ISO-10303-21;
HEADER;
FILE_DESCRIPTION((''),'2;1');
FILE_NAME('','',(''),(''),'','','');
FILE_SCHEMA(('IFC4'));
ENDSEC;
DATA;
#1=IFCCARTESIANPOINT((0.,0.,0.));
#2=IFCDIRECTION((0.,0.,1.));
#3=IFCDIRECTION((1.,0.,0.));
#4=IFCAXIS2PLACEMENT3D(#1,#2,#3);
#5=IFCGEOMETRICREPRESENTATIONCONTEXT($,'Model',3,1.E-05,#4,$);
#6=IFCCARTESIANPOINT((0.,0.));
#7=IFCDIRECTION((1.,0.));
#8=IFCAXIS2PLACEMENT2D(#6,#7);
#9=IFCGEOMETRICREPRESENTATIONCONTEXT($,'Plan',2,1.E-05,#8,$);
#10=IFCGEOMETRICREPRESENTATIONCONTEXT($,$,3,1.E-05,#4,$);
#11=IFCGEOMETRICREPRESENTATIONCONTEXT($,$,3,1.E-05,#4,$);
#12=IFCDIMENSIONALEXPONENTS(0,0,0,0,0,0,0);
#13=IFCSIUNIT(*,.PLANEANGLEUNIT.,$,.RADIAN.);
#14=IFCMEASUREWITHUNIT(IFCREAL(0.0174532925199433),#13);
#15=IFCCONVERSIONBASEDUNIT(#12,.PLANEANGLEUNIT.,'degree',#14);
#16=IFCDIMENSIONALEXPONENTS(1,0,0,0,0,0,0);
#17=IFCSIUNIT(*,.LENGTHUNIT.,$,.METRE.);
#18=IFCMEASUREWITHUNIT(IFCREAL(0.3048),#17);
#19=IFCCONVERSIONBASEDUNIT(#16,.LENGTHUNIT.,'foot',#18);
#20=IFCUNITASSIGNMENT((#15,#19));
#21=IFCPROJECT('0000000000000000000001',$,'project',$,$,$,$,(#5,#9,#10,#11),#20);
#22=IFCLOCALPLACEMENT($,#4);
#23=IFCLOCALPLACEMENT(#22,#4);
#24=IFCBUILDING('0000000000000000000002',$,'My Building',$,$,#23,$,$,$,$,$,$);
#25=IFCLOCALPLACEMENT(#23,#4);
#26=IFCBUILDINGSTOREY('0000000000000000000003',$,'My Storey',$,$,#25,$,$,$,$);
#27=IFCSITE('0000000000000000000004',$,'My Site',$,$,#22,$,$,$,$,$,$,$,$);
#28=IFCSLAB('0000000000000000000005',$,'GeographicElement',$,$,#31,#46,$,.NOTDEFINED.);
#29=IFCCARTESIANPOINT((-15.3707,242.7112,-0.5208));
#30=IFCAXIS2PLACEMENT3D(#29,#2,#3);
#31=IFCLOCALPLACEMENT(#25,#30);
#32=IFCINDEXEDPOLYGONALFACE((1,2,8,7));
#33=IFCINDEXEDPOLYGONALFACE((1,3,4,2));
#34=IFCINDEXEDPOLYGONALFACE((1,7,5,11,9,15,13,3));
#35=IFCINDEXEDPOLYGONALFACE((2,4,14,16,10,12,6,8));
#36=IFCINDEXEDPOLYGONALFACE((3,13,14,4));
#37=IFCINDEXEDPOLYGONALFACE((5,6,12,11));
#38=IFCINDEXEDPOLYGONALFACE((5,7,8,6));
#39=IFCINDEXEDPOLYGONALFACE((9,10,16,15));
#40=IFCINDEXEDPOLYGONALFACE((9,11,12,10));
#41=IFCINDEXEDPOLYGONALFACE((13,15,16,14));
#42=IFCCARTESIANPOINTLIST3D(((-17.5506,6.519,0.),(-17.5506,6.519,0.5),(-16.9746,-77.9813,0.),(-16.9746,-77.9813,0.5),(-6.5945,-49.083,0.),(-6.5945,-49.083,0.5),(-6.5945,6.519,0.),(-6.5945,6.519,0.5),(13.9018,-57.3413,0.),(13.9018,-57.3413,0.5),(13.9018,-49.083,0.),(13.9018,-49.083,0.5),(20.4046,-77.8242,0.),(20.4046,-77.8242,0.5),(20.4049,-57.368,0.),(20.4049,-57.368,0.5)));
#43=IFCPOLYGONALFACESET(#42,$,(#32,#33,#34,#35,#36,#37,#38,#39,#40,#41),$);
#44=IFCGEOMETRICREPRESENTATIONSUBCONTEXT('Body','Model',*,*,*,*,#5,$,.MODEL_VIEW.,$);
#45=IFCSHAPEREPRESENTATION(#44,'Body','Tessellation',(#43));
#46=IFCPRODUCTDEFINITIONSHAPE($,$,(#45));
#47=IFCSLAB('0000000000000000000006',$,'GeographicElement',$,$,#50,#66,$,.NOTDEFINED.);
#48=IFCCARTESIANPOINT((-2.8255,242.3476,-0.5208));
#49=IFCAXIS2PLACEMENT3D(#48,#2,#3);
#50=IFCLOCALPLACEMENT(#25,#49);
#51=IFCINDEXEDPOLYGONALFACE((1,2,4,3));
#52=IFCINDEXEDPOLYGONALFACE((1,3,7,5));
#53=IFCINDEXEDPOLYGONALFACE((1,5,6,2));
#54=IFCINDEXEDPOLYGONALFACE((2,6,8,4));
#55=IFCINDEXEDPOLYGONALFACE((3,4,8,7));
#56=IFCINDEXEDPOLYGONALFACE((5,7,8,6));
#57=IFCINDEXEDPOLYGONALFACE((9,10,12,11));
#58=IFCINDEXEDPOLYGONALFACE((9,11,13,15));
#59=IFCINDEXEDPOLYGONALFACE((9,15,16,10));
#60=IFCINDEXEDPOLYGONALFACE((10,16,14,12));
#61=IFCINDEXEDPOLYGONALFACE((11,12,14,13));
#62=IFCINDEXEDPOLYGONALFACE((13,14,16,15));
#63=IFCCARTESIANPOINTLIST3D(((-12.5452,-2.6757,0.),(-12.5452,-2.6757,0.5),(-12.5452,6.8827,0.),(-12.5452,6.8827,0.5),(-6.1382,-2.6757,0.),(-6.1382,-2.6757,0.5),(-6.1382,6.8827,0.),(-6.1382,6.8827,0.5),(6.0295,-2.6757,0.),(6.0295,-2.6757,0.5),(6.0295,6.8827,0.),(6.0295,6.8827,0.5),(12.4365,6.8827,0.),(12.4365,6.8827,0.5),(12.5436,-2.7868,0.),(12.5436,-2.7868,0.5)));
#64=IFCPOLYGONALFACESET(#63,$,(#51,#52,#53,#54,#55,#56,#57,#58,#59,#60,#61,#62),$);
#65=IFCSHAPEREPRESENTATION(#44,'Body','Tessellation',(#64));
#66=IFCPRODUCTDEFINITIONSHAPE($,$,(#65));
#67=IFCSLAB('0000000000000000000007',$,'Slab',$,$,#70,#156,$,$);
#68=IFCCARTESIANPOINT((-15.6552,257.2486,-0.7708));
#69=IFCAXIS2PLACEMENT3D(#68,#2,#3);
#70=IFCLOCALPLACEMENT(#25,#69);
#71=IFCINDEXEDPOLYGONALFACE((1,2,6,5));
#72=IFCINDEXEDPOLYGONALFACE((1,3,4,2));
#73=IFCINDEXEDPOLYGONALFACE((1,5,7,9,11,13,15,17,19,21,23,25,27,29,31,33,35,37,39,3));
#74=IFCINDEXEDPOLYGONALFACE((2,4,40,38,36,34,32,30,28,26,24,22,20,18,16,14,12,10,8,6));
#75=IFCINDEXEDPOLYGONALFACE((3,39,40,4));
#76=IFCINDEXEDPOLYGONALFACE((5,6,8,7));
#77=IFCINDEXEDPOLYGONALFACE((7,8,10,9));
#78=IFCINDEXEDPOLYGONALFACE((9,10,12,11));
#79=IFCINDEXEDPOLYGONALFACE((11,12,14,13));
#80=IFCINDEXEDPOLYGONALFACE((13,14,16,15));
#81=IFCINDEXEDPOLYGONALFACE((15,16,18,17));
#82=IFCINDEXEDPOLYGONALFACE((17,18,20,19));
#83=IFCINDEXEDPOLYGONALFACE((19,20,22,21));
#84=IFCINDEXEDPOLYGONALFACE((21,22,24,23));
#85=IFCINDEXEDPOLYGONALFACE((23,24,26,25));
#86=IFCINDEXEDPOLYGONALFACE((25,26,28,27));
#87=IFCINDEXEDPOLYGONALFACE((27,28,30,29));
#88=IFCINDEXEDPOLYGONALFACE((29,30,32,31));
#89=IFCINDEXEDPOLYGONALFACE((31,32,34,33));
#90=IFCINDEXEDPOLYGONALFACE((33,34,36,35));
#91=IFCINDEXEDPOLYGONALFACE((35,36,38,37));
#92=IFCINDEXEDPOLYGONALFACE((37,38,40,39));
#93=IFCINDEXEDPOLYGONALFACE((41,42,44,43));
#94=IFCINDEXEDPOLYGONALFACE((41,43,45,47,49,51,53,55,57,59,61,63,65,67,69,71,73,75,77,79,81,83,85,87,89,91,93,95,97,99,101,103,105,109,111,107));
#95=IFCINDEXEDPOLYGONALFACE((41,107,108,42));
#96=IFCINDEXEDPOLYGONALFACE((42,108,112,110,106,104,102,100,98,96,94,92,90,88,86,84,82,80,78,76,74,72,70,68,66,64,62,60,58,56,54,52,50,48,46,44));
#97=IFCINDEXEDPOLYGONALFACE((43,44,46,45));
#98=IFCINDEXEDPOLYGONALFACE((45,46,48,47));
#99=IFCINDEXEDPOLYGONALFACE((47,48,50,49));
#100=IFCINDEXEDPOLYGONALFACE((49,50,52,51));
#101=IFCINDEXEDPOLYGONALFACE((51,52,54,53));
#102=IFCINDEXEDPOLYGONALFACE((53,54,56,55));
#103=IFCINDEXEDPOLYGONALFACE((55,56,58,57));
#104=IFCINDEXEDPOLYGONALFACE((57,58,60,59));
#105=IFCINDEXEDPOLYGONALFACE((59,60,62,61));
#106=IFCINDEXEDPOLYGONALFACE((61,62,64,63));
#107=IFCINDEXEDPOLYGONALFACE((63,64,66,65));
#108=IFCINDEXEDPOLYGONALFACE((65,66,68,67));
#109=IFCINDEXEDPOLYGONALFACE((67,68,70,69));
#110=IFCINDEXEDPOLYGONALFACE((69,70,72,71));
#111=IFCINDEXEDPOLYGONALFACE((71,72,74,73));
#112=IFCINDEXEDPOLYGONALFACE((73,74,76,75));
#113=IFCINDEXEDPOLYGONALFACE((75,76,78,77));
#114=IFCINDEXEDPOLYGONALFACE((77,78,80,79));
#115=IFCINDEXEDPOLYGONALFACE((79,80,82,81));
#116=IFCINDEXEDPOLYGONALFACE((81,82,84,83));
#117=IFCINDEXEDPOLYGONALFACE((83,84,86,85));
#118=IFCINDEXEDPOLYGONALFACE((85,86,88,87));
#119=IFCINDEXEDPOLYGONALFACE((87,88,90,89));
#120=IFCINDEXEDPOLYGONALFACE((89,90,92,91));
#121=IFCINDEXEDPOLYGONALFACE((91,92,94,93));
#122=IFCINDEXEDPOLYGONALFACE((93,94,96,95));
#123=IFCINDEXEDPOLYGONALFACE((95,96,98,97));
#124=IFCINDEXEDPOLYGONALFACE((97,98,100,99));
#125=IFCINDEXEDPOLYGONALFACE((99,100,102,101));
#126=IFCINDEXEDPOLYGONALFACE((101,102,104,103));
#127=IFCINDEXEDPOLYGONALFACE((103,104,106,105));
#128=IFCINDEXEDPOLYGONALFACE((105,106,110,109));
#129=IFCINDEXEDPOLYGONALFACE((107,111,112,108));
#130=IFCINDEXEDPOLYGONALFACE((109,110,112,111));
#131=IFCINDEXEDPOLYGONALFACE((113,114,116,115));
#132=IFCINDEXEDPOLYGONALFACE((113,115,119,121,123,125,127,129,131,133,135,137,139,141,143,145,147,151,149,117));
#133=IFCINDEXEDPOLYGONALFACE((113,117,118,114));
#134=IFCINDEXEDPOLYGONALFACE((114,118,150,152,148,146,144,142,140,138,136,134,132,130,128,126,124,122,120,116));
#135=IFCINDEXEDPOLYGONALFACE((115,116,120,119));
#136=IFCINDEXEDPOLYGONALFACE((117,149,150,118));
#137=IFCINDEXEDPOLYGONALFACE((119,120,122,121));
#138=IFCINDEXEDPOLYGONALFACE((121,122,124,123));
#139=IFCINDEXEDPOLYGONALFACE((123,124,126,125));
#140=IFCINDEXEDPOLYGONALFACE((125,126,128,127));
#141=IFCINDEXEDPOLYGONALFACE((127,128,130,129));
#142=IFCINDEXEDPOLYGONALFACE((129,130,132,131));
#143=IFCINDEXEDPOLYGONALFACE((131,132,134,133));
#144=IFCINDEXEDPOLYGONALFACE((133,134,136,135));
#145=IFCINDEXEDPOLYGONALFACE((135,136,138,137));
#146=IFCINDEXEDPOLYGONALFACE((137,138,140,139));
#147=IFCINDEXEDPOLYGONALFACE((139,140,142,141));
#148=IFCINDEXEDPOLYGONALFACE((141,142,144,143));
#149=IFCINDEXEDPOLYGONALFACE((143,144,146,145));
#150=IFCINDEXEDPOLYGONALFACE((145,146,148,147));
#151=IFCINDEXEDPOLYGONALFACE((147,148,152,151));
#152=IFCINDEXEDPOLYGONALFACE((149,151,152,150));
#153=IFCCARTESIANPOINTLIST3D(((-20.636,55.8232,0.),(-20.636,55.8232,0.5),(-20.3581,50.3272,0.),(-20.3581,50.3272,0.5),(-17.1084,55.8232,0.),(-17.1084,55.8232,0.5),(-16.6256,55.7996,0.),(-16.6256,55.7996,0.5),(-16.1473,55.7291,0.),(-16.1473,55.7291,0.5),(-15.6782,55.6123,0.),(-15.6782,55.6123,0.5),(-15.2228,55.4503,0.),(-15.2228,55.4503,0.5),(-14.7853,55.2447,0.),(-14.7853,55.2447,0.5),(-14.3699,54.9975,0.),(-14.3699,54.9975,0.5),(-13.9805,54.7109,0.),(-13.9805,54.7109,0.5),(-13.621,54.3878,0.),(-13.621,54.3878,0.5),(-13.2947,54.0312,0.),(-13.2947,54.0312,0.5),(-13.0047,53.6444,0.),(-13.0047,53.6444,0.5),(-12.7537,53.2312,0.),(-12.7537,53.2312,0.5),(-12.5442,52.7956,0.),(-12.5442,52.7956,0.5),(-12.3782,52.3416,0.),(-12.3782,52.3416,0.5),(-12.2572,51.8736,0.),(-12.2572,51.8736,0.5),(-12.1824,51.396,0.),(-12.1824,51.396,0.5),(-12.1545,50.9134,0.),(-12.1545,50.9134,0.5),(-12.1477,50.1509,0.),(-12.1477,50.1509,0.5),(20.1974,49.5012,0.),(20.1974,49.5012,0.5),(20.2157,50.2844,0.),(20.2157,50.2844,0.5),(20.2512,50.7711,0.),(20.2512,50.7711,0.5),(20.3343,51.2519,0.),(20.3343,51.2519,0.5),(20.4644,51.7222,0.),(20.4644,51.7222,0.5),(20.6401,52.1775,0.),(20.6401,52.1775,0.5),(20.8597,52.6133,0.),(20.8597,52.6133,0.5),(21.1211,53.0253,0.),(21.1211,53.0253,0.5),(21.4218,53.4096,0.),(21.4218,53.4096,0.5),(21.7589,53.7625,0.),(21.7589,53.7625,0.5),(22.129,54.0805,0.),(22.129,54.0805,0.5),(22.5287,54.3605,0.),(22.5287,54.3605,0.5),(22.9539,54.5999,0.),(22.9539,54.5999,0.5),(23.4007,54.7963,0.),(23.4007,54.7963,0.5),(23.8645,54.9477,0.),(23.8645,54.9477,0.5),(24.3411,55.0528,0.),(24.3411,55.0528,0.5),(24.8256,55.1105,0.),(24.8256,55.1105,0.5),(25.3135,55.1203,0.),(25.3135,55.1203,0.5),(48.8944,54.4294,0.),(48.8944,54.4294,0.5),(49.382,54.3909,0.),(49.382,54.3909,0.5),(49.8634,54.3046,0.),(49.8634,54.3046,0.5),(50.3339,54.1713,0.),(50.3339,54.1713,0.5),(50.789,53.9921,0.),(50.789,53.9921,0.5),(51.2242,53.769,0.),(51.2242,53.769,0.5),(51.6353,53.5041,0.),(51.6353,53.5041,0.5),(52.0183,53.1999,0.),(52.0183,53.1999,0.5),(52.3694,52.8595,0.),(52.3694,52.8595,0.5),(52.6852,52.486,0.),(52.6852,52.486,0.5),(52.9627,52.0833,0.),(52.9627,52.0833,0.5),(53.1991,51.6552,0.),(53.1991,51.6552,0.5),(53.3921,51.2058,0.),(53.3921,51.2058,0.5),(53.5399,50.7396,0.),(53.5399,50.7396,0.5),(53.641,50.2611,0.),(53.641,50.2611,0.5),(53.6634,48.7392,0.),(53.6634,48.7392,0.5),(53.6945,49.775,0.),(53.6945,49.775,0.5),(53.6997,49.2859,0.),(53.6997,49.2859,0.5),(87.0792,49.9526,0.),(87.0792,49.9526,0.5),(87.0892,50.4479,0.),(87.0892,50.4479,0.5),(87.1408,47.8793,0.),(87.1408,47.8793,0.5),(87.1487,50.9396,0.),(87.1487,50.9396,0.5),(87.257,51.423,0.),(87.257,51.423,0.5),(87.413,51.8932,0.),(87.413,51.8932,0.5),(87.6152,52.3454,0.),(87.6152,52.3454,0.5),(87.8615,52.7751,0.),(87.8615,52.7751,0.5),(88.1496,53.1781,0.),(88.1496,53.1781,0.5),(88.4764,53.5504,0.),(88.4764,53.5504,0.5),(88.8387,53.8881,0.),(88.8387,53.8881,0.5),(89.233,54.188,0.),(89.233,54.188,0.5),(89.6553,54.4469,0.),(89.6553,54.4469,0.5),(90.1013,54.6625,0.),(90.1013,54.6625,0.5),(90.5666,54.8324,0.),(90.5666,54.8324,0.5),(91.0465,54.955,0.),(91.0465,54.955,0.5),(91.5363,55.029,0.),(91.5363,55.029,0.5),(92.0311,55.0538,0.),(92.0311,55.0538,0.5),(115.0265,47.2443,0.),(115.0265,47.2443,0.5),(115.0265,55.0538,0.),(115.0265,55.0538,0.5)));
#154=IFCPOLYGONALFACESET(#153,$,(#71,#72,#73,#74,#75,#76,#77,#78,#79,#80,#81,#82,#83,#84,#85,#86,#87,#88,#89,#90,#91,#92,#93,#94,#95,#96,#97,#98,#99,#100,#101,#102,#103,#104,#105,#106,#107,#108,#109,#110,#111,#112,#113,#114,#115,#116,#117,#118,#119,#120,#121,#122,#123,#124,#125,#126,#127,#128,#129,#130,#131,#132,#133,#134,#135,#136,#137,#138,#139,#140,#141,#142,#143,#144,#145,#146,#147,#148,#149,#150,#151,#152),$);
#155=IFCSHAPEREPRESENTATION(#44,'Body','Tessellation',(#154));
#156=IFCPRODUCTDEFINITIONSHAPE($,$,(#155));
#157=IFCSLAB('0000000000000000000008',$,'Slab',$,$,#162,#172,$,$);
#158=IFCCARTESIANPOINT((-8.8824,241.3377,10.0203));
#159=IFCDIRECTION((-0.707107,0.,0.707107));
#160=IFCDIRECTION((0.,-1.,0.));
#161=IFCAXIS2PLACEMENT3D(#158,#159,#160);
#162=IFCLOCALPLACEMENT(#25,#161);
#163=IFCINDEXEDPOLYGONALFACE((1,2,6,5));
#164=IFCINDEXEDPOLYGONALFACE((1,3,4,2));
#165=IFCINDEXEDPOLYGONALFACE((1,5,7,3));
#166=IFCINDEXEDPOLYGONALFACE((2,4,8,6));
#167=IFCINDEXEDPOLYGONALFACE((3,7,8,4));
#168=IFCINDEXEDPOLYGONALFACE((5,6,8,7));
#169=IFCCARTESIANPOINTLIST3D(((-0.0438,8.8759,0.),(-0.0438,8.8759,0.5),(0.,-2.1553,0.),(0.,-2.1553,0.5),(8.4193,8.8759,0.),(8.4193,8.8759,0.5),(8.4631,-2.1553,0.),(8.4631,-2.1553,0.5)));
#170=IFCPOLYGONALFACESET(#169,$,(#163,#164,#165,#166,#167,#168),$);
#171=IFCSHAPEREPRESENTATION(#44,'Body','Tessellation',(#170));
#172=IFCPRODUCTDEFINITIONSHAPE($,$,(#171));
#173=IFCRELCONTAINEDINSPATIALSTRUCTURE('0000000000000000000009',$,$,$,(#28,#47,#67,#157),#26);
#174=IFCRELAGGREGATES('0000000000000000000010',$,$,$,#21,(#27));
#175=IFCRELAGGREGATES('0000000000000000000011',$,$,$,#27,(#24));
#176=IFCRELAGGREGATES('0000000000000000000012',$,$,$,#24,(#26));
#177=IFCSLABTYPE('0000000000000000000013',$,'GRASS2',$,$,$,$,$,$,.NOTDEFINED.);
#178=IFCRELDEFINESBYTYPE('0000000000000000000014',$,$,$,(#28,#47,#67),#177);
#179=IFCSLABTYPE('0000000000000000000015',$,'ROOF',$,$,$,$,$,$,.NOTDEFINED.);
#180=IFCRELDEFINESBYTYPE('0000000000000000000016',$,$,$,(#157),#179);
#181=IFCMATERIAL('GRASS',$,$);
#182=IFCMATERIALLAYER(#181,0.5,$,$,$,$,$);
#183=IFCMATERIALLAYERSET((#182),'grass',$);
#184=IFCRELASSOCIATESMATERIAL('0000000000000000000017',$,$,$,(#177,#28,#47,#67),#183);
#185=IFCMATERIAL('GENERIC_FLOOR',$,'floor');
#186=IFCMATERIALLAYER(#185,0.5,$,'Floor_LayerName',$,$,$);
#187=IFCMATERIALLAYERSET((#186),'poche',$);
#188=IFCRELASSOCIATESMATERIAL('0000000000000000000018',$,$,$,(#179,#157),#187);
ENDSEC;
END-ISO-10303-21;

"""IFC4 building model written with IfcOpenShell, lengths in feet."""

from ifc_helpers import new_model, entity, si_unit, converted_unit, frame, origin_with_axes, origin_2d_with_axis, place, context, subcontext, project, spatial, line, arc, indexed_curve, outline, extrude, material, layer, layer_set, layer_usage, type_object, element, save


model = new_model("IFC4")

# Units and contexts
model_context = context("Model", 3, precision=1e-05, world=origin_with_axes())
plan_context = context("Plan", 2, precision=1e-05, world=origin_2d_with_axis())
context_of_model_1 = context(None, 3, precision=1e-05, world=origin_with_axes())
context_of_model_2 = context(None, 3, precision=1e-05, world=origin_with_axes())
body_context_1 = subcontext(model_context, "Body", "Model", "MODEL_VIEW")
ifc_project = project(units=[converted_unit("PLANEANGLEUNIT", "degree", entity("IfcReal", 0.0174532925199433), si_unit("PLANEANGLEUNIT", "RADIAN"), dimensions=[0, 0, 0, 0, 0, 0, 0]), converted_unit("LENGTHUNIT", "foot", entity("IfcReal", 0.3048), si_unit("LENGTHUNIT", "METRE"), dimensions=[1, 0, 0, 0, 0, 0, 0])], contexts=[model_context, plan_context, context_of_model_1, context_of_model_2])

# Site, building, storey
site_placement = place(None, origin_with_axes())
site = spatial("IfcSite", under=ifc_project, at=site_placement, Name="My Site")
building_placement = place(site_placement, origin_with_axes())
building = spatial("IfcBuilding", under=site, at=building_placement, Name="My Building")
storey_placement = place(building_placement, origin_with_axes())
storey = spatial("IfcBuildingStorey", under=building, at=storey_placement, Name="My Storey")

# Slabs
ifc_material_1 = material(Name="GRASS")
ifc_layer_1 = layer(ifc_material_1, 0.5)
ifc_layer_set_1 = layer_set([ifc_layer_1], Name="grass")
ifc_layer_usage_1 = layer_usage(ifc_layer_set_1, "AXIS3", "POSITIVE", 0.0)
slab_type_1 = type_object("IfcSlabType", Name="GRASS2", PredefinedType="NOTDEFINED", material=ifc_layer_set_1)
slab_1_placement = place(storey_placement, frame((-15.3707, 242.7112, -0.5208), z_axis=(0.0, 0.0, 1.0), x_axis=(1.0, 0.0, 0.0)))
element("IfcSlab", 1, at=slab_1_placement, inside=storey, type_object=slab_type_1, material=ifc_layer_usage_1, Name="GeographicElement", PredefinedType="NOTDEFINED", context=body_context_1, shape_type="SweptSolid", body=[
    extrude(outline(indexed_curve([(-6.5945, 6.519), (-6.5945, -49.083), (13.9018, -49.083), (13.9018, -57.3413), (20.4049, -57.368), (20.4046, -77.8242), (-16.9746, -77.9813), (-17.5506, 6.519)], segments=[line(3, 2), line(2, 1), line(1, 8), line(8, 7), line(7, 6), line(6, 5), line(5, 4), line(4, 3)], self_intersect=False)), None, (0.0, 0.0, 1.0), 0.5),
])
ifc_layer_usage_2 = layer_usage(ifc_layer_set_1, "AXIS3", "POSITIVE", 0.0)
slab_2_placement = place(storey_placement, frame((-2.8255, 242.3476, -0.5208), z_axis=(0.0, 0.0, 1.0), x_axis=(1.0, 0.0, 0.0)))
element("IfcSlab", 2, at=slab_2_placement, inside=storey, type_object=slab_type_1, material=ifc_layer_usage_2, Name="GeographicElement", PredefinedType="NOTDEFINED", context=body_context_1, shape_type="SweptSolid", body=[
    extrude(outline(indexed_curve([(-12.5452, -2.6757), (-6.1382, -2.6757), (-6.1382, 6.8827), (-12.5452, 6.8827), (6.0295, -2.6757), (6.0295, 6.8827), (12.4365, 6.8827), (12.5436, -2.7868)], segments=[line(7, 6), line(6, 5), line(5, 8), line(8, 7)], self_intersect=False), holes=[indexed_curve([(-12.5452, -2.6757), (-6.1382, -2.6757), (-6.1382, 6.8827), (-12.5452, 6.8827), (6.0295, -2.6757), (6.0295, 6.8827), (12.4365, 6.8827), (12.5436, -2.7868)], segments=[line(3, 4), line(4, 1), line(1, 2), line(2, 3)], self_intersect=False)]), None, (0.0, 0.0, 1.0), 0.5),
])
ifc_layer_usage_3 = layer_usage(ifc_layer_set_1, "AXIS3", "POSITIVE", 0.0)
slab_3_placement = place(storey_placement, frame((-15.6552, 257.2486, -0.7708), z_axis=(0.0, 0.0, 1.0), x_axis=(1.0, 0.0, 0.0)))
element("IfcSlab", 3, at=slab_3_placement, inside=storey, type_object=slab_type_1, material=ifc_layer_usage_3, Name="Slab", context=body_context_1, shape_type="SweptSolid", body=[
    extrude(outline(indexed_curve([(87.1408, 47.8793), (115.0265, 47.2443), (115.0265, 55.0538), (92.0311, 55.0538), (88.4764, 53.5504), (87.0792, 49.9526), (25.3135, 55.1203), (21.7589, 53.7625), (20.2157, 50.2844), (20.1974, 49.5012), (53.6634, 48.7392), (53.6997, 49.2859), (52.3694, 52.8595), (48.8944, 54.4294), (-12.1477, 50.1509), (-20.3581, 50.3272), (-20.636, 55.8232), (-17.1084, 55.8232), (-13.621, 54.3878), (-12.1545, 50.9134)], segments=[line(1, 2), line(2, 3), line(3, 4), arc(4, 5, 6), line(6, 1)], self_intersect=False), holes=[indexed_curve([(87.1408, 47.8793), (115.0265, 47.2443), (115.0265, 55.0538), (92.0311, 55.0538), (88.4764, 53.5504), (87.0792, 49.9526), (25.3135, 55.1203), (21.7589, 53.7625), (20.2157, 50.2844), (20.1974, 49.5012), (53.6634, 48.7392), (53.6997, 49.2859), (52.3694, 52.8595), (48.8944, 54.4294), (-12.1477, 50.1509), (-20.3581, 50.3272), (-20.636, 55.8232), (-17.1084, 55.8232), (-13.621, 54.3878), (-12.1545, 50.9134)], segments=[line(17, 16), line(16, 15), line(15, 20), arc(20, 19, 18), line(18, 17)], self_intersect=False), indexed_curve([(87.1408, 47.8793), (115.0265, 47.2443), (115.0265, 55.0538), (92.0311, 55.0538), (88.4764, 53.5504), (87.0792, 49.9526), (25.3135, 55.1203), (21.7589, 53.7625), (20.2157, 50.2844), (20.1974, 49.5012), (53.6634, 48.7392), (53.6997, 49.2859), (52.3694, 52.8595), (48.8944, 54.4294), (-12.1477, 50.1509), (-20.3581, 50.3272), (-20.636, 55.8232), (-17.1084, 55.8232), (-13.621, 54.3878), (-12.1545, 50.9134)], segments=[line(11, 12), arc(12, 13, 14), line(14, 7), arc(7, 8, 9), line(9, 10), line(10, 11)], self_intersect=False)]), None, (0.0, 0.0, 1.0), 0.5),
])
ifc_material_2 = material(Name="GENERIC_FLOOR", Category="floor")
ifc_layer_2 = layer(ifc_material_2, 0.5, Name="Floor_LayerName")
ifc_layer_set_2 = layer_set([ifc_layer_2], Name="poche")
ifc_layer_usage_4 = layer_usage(ifc_layer_set_2, "AXIS3", "POSITIVE", 0.0)
slab_type_2 = type_object("IfcSlabType", Name="ROOF", PredefinedType="NOTDEFINED", material=ifc_layer_set_2)
slab_4_placement = place(storey_placement, frame((-8.8824, 241.3377, 10.0203), z_axis=(-0.707107, 0.0, 0.707107), x_axis=(0.0, -1.0, 0.0)))
element("IfcSlab", 4, at=slab_4_placement, inside=storey, type_object=slab_type_2, material=ifc_layer_usage_4, Name="Slab", context=body_context_1, shape_type="SweptSolid", body=[
    extrude(outline(indexed_curve([(0.0, -2.1553), (8.4631, -2.1553), (8.4193, 8.8759), (-0.0438, 8.8759)], segments=[line(3, 2), line(2, 1), line(1, 4), line(4, 3)], self_intersect=False)), None, (0.0, 0.0, 1.0), 0.5),
])

save(model, "model.ifc")
